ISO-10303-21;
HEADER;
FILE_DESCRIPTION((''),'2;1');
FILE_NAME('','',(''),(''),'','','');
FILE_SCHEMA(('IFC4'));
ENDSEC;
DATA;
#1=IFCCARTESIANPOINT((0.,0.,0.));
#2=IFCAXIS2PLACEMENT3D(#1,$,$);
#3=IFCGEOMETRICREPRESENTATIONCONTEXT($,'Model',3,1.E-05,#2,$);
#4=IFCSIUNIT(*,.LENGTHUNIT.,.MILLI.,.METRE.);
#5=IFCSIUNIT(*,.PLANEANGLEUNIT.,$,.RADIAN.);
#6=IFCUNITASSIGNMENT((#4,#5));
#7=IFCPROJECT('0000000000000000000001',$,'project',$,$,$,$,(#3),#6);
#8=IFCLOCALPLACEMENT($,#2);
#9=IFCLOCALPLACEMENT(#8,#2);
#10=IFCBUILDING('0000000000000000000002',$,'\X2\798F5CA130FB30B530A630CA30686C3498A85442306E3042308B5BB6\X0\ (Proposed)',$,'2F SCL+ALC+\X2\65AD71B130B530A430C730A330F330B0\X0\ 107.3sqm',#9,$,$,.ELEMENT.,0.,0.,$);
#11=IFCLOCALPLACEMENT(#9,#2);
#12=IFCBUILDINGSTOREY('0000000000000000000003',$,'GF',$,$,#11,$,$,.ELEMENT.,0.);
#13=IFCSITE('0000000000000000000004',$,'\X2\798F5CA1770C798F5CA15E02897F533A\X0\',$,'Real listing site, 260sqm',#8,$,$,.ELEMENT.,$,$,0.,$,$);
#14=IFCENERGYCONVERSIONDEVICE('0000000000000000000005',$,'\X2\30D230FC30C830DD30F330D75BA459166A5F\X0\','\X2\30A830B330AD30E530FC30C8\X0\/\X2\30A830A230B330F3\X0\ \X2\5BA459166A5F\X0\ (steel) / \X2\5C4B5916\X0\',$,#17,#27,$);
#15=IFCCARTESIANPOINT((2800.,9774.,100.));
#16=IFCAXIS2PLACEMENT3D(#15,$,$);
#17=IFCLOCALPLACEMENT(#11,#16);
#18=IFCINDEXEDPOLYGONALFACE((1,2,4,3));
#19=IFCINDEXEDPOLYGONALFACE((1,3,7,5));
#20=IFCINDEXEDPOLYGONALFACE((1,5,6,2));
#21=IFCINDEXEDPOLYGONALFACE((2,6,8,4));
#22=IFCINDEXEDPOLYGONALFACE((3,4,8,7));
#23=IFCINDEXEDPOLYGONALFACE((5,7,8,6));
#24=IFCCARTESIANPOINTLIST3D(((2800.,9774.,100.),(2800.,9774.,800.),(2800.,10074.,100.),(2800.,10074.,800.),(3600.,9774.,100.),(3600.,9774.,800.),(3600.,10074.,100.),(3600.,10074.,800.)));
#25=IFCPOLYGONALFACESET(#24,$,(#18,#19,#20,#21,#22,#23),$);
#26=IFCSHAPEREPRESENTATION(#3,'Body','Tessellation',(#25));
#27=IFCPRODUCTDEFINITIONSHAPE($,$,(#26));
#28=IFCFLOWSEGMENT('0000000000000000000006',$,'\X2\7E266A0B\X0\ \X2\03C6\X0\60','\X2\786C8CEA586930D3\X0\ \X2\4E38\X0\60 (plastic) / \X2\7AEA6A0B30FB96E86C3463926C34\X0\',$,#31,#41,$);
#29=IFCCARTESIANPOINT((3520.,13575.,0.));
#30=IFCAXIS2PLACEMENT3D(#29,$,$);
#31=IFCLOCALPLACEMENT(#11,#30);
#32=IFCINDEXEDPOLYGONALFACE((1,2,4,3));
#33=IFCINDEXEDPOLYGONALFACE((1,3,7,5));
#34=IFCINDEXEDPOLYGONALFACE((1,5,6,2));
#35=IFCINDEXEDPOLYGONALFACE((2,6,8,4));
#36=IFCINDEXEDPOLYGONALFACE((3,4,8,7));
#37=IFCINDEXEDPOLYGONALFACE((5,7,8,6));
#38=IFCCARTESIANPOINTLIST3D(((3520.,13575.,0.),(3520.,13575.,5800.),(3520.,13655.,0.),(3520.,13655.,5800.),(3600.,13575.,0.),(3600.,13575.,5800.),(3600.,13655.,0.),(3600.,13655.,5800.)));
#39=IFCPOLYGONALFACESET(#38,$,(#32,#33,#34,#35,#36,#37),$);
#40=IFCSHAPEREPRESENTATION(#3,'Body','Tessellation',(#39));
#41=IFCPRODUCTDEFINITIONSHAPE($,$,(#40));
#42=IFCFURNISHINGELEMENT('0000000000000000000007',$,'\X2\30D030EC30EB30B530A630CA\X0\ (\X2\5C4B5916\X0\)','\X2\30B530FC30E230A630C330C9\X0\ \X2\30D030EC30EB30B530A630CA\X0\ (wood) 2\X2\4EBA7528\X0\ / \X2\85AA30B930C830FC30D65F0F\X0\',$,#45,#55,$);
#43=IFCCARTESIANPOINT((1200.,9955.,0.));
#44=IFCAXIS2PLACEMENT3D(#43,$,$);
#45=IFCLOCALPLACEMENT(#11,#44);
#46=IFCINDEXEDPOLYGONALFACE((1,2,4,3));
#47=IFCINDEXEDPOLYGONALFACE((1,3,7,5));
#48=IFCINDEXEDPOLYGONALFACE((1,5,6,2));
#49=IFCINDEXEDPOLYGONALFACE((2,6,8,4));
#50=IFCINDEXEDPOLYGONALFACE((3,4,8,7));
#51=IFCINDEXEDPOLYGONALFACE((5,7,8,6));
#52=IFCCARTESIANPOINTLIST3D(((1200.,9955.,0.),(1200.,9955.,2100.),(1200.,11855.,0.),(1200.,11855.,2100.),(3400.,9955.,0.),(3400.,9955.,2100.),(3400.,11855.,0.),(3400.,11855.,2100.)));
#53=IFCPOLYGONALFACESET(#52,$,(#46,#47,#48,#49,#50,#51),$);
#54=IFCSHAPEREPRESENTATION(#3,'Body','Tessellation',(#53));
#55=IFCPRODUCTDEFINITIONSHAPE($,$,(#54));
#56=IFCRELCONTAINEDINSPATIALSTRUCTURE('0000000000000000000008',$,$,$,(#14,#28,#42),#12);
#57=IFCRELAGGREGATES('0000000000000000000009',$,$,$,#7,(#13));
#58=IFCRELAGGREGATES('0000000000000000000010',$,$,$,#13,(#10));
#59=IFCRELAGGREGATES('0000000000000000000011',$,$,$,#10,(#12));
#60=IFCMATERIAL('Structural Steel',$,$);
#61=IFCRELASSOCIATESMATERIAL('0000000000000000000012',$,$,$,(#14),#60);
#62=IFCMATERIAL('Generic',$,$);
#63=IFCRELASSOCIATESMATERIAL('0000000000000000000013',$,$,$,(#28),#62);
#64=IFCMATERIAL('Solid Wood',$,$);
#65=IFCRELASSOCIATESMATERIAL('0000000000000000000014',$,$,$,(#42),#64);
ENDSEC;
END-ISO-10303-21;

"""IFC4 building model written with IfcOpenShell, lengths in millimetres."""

from ifc_helpers import new_model, si_unit, frame, frame_2d, origin, place, context, project, spatial, rectangle, extrude, material, element, save


model = new_model("IFC4")

# Units and contexts
model_context = context("Model", 3, precision=1e-05, world=origin())
ifc_project = project(units=[si_unit("LENGTHUNIT", "METRE", prefix="MILLI"), si_unit("PLANEANGLEUNIT", "RADIAN")], contexts=[model_context])

# Site, building, storey
site_placement = place(None, origin())
site = spatial("IfcSite", under=ifc_project, at=site_placement, Name="福岡県福岡市西区", ObjectType="Real listing site, 260sqm", CompositionType="ELEMENT", RefElevation=0.0)
building_placement = place(site_placement, origin())
building = spatial("IfcBuilding", under=site, at=building_placement, Name="福岡・サウナと水風呂のある家 (Proposed)", ObjectType="2F SCL+ALC+断熱サイディング 107.3sqm", CompositionType="ELEMENT", ElevationOfRefHeight=0.0, ElevationOfTerrain=0.0)
storey_placement = place(building_placement, origin())
storey = spatial("IfcBuildingStorey", under=building, at=storey_placement, Name="GF", CompositionType="ELEMENT", Elevation=0.0)

# Shared definitions
ifc_material_1 = material(Name="Solid Wood")

# Shared definitions
ifc_material_2 = material(Name="Generic")

# Energy conversion device
ifc_material_3 = material(Name="Structural Steel")
energy_conversion_device_placement = place(storey_placement, frame((2800.0, 9774.0, 100.0)))
element("IfcEnergyConversionDevice", 1, at=energy_conversion_device_placement, inside=storey, material=ifc_material_3, Name="ヒートポンプ室外機", Description="エコキュート/エアコン 室外機 (steel) / 屋外", context=model_context, shape_type="SweptSolid", body=[
    extrude(rectangle(XDim=800.0, YDim=300.0, at=frame_2d((400.0, 150.0))), frame((2800.0, 9774.0, 100.0)), (0.0, 0.0, 1.0), 700.0),
])

# Flow segment
flow_segment_placement = place(storey_placement, frame((3520.0, 13575.0, 0.0)))
element("IfcFlowSegment", 2, at=flow_segment_placement, inside=storey, material=ifc_material_2, Name="縦樋 φ60", Description="硬質塩ビ 丸60 (plastic) / 竪樋・雨水排水", context=model_context, shape_type="SweptSolid", body=[
    extrude(rectangle(XDim=80.0, YDim=80.0, at=frame_2d((40.0, 40.0))), frame((3520.0, 13575.0, 0.0)), (0.0, 0.0, 1.0), 5800.0),
])

# Furnishing element
furnishing_placement = place(storey_placement, frame((1200.0, 9955.0, 0.0)))
element("IfcFurnishingElement", 3, at=furnishing_placement, inside=storey, material=ifc_material_1, Name="バレルサウナ (屋外)", Description="サーモウッド バレルサウナ (wood) 2人用 / 薪ストーブ式", context=model_context, shape_type="SweptSolid", body=[
    extrude(rectangle(XDim=2200.0, YDim=1900.0, at=frame_2d((1100.0, 950.0))), frame((1200.0, 9955.0, 0.0)), (0.0, 0.0, 1.0), 2100.0),
])

save(model, "model.ifc")
